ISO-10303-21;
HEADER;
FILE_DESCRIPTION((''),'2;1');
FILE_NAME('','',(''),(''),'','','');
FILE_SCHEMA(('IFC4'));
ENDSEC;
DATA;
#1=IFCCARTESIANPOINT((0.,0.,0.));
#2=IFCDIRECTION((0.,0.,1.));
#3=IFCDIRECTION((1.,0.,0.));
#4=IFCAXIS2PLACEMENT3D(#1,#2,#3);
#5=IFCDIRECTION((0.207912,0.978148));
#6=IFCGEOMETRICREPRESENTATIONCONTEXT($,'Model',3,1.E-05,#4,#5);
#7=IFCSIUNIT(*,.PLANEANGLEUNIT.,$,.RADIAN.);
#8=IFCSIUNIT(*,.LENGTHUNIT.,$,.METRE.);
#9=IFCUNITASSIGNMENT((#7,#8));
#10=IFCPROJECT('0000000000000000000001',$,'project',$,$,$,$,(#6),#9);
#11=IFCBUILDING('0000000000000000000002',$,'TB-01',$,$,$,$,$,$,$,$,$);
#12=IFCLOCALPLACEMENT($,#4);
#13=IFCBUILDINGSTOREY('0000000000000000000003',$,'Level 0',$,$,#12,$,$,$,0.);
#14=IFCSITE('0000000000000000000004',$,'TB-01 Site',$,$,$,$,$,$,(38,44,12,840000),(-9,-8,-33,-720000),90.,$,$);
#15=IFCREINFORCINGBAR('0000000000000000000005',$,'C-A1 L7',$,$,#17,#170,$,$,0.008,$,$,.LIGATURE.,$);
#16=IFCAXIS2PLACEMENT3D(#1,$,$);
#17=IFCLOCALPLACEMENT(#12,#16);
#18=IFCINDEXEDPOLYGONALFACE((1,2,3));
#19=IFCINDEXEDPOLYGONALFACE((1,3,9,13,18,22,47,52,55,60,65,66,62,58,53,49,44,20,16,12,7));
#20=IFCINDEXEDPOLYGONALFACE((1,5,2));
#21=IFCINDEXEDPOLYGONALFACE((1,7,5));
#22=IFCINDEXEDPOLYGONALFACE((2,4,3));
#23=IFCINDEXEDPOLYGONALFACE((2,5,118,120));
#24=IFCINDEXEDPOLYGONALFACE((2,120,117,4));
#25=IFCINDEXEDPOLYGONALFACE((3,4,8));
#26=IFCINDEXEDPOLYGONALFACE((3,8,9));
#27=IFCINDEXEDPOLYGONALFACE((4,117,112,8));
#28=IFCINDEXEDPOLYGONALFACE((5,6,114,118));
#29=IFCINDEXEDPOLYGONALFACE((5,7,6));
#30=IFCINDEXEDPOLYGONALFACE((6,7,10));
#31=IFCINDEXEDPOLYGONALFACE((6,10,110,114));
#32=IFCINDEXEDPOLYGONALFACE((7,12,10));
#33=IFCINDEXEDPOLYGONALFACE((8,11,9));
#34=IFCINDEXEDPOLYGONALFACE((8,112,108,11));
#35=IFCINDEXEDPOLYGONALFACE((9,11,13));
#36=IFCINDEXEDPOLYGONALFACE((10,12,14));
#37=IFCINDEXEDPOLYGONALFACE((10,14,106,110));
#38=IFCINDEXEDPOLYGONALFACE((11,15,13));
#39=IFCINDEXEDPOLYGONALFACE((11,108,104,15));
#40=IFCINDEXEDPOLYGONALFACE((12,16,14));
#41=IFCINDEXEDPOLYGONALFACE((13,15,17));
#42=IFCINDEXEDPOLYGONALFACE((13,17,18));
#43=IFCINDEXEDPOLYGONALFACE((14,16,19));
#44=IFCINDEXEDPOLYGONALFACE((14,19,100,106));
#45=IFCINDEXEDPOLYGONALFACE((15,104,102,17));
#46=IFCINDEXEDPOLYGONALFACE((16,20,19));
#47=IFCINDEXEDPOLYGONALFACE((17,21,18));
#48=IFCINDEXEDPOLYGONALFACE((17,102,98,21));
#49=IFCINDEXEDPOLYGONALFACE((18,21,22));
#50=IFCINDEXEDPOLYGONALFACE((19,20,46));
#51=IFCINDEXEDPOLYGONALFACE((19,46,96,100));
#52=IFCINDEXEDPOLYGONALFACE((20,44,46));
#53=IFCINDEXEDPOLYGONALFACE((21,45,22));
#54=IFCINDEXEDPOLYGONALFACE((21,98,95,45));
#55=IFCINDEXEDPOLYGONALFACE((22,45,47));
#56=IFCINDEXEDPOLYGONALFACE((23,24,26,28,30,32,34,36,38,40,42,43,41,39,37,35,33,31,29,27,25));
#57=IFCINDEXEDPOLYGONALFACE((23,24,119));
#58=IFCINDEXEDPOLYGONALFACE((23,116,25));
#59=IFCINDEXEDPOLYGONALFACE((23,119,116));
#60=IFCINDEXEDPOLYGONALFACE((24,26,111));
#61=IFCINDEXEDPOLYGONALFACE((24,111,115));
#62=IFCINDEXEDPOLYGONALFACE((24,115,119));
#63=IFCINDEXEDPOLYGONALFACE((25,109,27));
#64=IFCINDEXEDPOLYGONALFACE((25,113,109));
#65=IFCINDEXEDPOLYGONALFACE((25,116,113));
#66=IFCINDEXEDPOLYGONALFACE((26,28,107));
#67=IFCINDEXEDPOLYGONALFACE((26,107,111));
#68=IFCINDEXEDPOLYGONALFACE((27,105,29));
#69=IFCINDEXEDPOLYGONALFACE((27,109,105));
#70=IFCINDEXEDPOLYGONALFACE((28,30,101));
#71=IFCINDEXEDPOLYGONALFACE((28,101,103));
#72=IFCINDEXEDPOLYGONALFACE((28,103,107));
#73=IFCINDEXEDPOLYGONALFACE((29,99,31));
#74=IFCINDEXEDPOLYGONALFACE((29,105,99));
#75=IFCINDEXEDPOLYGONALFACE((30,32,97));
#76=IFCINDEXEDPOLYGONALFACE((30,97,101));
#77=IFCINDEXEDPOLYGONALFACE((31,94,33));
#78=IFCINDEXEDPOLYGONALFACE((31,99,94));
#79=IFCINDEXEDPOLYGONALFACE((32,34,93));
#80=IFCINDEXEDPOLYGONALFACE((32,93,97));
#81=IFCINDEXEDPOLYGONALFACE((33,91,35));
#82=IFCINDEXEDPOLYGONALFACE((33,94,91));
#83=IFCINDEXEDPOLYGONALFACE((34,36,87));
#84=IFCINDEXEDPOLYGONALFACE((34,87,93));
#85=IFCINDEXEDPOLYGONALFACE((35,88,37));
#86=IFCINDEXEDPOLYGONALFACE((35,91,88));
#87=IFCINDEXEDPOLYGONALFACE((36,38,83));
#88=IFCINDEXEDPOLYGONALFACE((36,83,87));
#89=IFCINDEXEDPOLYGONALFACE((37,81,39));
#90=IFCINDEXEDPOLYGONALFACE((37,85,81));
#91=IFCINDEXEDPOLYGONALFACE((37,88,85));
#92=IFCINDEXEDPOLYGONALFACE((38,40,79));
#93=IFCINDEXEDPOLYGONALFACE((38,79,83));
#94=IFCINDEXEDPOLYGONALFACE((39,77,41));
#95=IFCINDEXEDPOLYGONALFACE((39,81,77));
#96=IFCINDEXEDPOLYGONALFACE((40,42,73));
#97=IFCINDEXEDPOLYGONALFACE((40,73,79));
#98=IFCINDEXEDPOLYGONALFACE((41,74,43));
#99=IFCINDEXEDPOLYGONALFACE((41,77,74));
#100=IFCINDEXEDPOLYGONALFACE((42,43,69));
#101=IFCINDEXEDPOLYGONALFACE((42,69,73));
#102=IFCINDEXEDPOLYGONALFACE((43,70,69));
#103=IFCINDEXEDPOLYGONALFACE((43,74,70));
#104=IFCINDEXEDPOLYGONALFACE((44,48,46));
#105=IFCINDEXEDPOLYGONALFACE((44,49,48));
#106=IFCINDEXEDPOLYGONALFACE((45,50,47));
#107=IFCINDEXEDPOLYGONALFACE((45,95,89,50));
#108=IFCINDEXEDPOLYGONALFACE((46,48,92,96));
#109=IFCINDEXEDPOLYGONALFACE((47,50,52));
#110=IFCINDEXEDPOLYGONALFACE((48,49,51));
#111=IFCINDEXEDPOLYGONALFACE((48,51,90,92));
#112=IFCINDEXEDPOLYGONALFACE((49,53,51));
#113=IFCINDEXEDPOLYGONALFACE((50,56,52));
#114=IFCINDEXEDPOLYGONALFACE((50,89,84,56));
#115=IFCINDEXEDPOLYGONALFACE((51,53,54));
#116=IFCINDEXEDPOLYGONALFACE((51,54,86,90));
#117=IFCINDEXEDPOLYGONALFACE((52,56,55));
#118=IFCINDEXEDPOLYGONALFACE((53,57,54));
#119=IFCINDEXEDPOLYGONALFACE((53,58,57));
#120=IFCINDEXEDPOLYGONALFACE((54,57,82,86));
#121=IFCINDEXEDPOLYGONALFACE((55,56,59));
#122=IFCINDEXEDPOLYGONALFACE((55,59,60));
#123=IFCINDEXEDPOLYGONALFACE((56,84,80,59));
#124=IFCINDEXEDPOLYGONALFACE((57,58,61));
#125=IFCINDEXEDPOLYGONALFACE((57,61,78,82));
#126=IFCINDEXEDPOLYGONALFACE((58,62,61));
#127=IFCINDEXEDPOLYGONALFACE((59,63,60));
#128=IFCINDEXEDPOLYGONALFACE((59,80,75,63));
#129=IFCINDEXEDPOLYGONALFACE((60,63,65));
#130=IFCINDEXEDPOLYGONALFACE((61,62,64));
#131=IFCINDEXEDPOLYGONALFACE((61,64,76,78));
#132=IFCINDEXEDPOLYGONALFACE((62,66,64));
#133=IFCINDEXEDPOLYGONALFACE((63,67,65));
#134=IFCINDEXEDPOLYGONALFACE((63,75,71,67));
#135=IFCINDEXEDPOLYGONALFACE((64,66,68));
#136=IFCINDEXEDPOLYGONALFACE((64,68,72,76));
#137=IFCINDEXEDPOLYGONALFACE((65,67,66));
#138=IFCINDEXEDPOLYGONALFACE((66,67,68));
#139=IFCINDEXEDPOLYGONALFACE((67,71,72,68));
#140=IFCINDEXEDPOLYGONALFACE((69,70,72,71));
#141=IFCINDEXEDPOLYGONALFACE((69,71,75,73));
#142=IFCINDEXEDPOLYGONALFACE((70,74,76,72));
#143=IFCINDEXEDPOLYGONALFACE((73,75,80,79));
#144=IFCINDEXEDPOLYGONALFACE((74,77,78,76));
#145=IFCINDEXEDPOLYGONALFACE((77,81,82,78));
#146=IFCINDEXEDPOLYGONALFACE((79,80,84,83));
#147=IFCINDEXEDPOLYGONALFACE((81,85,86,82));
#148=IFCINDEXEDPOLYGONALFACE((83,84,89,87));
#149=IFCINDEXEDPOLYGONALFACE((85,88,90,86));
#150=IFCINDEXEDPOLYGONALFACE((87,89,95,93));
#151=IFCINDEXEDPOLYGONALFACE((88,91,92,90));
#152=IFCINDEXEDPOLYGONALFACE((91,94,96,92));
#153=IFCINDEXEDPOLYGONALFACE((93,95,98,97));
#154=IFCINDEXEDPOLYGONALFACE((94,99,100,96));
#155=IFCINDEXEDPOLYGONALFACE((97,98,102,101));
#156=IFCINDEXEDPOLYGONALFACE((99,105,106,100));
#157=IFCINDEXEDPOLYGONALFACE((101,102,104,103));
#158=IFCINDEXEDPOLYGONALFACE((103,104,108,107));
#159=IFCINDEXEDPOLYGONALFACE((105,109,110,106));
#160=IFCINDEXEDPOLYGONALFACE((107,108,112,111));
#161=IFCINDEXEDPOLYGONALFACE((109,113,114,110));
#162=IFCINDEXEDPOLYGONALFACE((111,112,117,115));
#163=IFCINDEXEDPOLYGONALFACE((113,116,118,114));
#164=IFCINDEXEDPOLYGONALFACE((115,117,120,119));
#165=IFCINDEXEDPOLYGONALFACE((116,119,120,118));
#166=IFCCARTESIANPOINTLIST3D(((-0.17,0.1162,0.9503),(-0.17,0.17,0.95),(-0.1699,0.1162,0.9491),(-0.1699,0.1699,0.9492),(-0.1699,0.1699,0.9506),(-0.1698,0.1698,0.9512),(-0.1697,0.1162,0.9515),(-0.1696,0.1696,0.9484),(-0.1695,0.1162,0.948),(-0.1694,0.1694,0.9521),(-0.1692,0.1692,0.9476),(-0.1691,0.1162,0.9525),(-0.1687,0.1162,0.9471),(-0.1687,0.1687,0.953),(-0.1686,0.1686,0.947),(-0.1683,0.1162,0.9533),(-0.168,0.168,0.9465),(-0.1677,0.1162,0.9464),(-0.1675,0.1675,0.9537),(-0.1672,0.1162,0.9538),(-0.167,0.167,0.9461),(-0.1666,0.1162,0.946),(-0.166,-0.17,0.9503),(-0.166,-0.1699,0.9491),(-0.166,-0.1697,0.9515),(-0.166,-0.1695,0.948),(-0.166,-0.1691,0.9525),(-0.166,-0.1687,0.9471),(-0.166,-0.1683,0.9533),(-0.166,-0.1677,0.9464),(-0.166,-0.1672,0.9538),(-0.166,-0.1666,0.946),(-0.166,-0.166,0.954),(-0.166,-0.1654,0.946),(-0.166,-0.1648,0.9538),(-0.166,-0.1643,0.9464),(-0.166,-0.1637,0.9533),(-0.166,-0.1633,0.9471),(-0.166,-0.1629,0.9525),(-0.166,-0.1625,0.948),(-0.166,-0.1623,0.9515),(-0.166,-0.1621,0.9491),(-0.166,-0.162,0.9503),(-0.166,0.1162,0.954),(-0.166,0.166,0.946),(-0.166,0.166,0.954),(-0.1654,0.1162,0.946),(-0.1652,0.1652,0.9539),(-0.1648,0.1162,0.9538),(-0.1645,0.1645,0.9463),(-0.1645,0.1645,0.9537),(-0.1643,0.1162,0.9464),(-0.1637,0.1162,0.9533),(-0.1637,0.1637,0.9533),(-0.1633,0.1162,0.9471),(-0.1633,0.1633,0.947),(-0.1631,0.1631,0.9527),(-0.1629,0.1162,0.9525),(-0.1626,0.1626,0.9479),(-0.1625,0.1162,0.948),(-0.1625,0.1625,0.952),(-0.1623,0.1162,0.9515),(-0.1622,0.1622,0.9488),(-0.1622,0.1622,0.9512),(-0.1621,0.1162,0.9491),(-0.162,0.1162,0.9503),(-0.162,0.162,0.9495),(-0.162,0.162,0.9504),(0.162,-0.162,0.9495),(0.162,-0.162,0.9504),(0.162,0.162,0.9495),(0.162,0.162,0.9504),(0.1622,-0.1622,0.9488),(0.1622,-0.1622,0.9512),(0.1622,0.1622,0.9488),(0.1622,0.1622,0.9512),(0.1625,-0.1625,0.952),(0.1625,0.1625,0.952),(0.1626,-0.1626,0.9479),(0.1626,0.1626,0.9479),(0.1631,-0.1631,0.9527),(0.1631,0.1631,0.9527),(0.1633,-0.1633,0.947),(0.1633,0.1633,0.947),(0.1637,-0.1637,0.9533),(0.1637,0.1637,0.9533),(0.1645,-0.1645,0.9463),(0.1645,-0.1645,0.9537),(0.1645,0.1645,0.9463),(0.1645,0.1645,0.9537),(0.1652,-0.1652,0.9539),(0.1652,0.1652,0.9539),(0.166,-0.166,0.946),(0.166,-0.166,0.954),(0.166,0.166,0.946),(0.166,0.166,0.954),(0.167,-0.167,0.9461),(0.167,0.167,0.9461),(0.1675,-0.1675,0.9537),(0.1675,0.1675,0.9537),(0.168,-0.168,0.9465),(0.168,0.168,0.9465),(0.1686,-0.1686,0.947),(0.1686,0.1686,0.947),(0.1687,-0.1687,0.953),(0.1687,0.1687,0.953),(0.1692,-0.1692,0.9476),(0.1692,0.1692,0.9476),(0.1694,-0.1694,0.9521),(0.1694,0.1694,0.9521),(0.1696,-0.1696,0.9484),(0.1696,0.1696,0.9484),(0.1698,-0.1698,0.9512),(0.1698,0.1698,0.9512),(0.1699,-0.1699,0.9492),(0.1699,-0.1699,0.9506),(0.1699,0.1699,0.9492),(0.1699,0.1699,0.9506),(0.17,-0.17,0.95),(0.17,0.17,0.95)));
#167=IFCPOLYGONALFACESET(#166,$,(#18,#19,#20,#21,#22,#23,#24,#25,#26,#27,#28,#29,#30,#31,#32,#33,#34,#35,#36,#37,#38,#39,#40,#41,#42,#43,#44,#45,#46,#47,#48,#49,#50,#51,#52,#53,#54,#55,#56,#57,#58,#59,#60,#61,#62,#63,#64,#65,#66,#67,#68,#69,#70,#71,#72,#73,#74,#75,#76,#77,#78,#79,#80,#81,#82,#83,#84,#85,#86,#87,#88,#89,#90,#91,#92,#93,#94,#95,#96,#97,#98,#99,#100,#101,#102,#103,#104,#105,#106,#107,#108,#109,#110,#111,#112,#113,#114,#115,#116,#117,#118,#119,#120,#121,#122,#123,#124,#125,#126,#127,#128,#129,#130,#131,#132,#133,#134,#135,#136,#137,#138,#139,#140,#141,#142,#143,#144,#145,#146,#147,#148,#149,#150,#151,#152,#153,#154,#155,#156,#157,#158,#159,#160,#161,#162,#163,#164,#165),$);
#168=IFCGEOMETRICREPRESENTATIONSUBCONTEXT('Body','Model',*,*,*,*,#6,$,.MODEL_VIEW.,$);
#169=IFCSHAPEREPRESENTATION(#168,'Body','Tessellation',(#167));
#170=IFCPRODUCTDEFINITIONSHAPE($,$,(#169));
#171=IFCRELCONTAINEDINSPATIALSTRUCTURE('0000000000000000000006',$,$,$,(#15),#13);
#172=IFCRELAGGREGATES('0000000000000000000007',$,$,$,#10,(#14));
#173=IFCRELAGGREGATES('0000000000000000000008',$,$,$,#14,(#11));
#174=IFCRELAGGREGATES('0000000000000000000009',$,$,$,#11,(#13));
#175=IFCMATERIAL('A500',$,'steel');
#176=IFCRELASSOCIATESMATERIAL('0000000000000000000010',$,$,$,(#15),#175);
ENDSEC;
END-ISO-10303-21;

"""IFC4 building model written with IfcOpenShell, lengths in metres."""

from ifc_helpers import new_model, entity, si_unit, direction, origin_with_axes, place, context, subcontext, project, spatial, material, element, save


model = new_model("IFC4")

# Units and contexts
model_context = context("Model", 3, precision=1e-05, world=origin_with_axes(), true_north=direction((0.207912, 0.978148)))
body_context = subcontext(model_context, "Body", "Model", "MODEL_VIEW")
ifc_project = project(units=[si_unit("PLANEANGLEUNIT", "RADIAN"), si_unit("LENGTHUNIT", "METRE")], contexts=[model_context])

# Site, building, storey
site = spatial("IfcSite", under=ifc_project, Name="TB-01 Site", RefLatitude=(38, 44, 12, 840000), RefLongitude=(-9, -8, -33, -720000), RefElevation=90.0)
building = spatial("IfcBuilding", under=site, Name="TB-01")
storey_placement = place(None, origin_with_axes())
storey = spatial("IfcBuildingStorey", under=building, at=storey_placement, Name="Level 0", Elevation=0.0)

# Reinforcing bar
ifc_material_1 = material(Name="A500", Category="steel")
reinforcing_bar_1_placement = place(storey_placement, origin_with_axes())
element("IfcReinforcingBar", 1, at=reinforcing_bar_1_placement, inside=storey, material=ifc_material_1, Name="C-A1 L7", NominalDiameter=0.008, PredefinedType="LIGATURE", context=body_context, shape_type="AdvancedSweptSolid", body=[
    entity("IfcSweptDiskSolid", entity("IfcPolyline", [entity("IfcCartesianPoint", [-0.166, -0.166, 0.95]), entity("IfcCartesianPoint", [0.166, -0.166, 0.95]), entity("IfcCartesianPoint", [0.166, 0.166, 0.95]), entity("IfcCartesianPoint", [-0.166, 0.166, 0.95]), entity("IfcCartesianPoint", [-0.166, 0.1162, 0.95])]), 0.004),
])

save(model, "model.ifc")
